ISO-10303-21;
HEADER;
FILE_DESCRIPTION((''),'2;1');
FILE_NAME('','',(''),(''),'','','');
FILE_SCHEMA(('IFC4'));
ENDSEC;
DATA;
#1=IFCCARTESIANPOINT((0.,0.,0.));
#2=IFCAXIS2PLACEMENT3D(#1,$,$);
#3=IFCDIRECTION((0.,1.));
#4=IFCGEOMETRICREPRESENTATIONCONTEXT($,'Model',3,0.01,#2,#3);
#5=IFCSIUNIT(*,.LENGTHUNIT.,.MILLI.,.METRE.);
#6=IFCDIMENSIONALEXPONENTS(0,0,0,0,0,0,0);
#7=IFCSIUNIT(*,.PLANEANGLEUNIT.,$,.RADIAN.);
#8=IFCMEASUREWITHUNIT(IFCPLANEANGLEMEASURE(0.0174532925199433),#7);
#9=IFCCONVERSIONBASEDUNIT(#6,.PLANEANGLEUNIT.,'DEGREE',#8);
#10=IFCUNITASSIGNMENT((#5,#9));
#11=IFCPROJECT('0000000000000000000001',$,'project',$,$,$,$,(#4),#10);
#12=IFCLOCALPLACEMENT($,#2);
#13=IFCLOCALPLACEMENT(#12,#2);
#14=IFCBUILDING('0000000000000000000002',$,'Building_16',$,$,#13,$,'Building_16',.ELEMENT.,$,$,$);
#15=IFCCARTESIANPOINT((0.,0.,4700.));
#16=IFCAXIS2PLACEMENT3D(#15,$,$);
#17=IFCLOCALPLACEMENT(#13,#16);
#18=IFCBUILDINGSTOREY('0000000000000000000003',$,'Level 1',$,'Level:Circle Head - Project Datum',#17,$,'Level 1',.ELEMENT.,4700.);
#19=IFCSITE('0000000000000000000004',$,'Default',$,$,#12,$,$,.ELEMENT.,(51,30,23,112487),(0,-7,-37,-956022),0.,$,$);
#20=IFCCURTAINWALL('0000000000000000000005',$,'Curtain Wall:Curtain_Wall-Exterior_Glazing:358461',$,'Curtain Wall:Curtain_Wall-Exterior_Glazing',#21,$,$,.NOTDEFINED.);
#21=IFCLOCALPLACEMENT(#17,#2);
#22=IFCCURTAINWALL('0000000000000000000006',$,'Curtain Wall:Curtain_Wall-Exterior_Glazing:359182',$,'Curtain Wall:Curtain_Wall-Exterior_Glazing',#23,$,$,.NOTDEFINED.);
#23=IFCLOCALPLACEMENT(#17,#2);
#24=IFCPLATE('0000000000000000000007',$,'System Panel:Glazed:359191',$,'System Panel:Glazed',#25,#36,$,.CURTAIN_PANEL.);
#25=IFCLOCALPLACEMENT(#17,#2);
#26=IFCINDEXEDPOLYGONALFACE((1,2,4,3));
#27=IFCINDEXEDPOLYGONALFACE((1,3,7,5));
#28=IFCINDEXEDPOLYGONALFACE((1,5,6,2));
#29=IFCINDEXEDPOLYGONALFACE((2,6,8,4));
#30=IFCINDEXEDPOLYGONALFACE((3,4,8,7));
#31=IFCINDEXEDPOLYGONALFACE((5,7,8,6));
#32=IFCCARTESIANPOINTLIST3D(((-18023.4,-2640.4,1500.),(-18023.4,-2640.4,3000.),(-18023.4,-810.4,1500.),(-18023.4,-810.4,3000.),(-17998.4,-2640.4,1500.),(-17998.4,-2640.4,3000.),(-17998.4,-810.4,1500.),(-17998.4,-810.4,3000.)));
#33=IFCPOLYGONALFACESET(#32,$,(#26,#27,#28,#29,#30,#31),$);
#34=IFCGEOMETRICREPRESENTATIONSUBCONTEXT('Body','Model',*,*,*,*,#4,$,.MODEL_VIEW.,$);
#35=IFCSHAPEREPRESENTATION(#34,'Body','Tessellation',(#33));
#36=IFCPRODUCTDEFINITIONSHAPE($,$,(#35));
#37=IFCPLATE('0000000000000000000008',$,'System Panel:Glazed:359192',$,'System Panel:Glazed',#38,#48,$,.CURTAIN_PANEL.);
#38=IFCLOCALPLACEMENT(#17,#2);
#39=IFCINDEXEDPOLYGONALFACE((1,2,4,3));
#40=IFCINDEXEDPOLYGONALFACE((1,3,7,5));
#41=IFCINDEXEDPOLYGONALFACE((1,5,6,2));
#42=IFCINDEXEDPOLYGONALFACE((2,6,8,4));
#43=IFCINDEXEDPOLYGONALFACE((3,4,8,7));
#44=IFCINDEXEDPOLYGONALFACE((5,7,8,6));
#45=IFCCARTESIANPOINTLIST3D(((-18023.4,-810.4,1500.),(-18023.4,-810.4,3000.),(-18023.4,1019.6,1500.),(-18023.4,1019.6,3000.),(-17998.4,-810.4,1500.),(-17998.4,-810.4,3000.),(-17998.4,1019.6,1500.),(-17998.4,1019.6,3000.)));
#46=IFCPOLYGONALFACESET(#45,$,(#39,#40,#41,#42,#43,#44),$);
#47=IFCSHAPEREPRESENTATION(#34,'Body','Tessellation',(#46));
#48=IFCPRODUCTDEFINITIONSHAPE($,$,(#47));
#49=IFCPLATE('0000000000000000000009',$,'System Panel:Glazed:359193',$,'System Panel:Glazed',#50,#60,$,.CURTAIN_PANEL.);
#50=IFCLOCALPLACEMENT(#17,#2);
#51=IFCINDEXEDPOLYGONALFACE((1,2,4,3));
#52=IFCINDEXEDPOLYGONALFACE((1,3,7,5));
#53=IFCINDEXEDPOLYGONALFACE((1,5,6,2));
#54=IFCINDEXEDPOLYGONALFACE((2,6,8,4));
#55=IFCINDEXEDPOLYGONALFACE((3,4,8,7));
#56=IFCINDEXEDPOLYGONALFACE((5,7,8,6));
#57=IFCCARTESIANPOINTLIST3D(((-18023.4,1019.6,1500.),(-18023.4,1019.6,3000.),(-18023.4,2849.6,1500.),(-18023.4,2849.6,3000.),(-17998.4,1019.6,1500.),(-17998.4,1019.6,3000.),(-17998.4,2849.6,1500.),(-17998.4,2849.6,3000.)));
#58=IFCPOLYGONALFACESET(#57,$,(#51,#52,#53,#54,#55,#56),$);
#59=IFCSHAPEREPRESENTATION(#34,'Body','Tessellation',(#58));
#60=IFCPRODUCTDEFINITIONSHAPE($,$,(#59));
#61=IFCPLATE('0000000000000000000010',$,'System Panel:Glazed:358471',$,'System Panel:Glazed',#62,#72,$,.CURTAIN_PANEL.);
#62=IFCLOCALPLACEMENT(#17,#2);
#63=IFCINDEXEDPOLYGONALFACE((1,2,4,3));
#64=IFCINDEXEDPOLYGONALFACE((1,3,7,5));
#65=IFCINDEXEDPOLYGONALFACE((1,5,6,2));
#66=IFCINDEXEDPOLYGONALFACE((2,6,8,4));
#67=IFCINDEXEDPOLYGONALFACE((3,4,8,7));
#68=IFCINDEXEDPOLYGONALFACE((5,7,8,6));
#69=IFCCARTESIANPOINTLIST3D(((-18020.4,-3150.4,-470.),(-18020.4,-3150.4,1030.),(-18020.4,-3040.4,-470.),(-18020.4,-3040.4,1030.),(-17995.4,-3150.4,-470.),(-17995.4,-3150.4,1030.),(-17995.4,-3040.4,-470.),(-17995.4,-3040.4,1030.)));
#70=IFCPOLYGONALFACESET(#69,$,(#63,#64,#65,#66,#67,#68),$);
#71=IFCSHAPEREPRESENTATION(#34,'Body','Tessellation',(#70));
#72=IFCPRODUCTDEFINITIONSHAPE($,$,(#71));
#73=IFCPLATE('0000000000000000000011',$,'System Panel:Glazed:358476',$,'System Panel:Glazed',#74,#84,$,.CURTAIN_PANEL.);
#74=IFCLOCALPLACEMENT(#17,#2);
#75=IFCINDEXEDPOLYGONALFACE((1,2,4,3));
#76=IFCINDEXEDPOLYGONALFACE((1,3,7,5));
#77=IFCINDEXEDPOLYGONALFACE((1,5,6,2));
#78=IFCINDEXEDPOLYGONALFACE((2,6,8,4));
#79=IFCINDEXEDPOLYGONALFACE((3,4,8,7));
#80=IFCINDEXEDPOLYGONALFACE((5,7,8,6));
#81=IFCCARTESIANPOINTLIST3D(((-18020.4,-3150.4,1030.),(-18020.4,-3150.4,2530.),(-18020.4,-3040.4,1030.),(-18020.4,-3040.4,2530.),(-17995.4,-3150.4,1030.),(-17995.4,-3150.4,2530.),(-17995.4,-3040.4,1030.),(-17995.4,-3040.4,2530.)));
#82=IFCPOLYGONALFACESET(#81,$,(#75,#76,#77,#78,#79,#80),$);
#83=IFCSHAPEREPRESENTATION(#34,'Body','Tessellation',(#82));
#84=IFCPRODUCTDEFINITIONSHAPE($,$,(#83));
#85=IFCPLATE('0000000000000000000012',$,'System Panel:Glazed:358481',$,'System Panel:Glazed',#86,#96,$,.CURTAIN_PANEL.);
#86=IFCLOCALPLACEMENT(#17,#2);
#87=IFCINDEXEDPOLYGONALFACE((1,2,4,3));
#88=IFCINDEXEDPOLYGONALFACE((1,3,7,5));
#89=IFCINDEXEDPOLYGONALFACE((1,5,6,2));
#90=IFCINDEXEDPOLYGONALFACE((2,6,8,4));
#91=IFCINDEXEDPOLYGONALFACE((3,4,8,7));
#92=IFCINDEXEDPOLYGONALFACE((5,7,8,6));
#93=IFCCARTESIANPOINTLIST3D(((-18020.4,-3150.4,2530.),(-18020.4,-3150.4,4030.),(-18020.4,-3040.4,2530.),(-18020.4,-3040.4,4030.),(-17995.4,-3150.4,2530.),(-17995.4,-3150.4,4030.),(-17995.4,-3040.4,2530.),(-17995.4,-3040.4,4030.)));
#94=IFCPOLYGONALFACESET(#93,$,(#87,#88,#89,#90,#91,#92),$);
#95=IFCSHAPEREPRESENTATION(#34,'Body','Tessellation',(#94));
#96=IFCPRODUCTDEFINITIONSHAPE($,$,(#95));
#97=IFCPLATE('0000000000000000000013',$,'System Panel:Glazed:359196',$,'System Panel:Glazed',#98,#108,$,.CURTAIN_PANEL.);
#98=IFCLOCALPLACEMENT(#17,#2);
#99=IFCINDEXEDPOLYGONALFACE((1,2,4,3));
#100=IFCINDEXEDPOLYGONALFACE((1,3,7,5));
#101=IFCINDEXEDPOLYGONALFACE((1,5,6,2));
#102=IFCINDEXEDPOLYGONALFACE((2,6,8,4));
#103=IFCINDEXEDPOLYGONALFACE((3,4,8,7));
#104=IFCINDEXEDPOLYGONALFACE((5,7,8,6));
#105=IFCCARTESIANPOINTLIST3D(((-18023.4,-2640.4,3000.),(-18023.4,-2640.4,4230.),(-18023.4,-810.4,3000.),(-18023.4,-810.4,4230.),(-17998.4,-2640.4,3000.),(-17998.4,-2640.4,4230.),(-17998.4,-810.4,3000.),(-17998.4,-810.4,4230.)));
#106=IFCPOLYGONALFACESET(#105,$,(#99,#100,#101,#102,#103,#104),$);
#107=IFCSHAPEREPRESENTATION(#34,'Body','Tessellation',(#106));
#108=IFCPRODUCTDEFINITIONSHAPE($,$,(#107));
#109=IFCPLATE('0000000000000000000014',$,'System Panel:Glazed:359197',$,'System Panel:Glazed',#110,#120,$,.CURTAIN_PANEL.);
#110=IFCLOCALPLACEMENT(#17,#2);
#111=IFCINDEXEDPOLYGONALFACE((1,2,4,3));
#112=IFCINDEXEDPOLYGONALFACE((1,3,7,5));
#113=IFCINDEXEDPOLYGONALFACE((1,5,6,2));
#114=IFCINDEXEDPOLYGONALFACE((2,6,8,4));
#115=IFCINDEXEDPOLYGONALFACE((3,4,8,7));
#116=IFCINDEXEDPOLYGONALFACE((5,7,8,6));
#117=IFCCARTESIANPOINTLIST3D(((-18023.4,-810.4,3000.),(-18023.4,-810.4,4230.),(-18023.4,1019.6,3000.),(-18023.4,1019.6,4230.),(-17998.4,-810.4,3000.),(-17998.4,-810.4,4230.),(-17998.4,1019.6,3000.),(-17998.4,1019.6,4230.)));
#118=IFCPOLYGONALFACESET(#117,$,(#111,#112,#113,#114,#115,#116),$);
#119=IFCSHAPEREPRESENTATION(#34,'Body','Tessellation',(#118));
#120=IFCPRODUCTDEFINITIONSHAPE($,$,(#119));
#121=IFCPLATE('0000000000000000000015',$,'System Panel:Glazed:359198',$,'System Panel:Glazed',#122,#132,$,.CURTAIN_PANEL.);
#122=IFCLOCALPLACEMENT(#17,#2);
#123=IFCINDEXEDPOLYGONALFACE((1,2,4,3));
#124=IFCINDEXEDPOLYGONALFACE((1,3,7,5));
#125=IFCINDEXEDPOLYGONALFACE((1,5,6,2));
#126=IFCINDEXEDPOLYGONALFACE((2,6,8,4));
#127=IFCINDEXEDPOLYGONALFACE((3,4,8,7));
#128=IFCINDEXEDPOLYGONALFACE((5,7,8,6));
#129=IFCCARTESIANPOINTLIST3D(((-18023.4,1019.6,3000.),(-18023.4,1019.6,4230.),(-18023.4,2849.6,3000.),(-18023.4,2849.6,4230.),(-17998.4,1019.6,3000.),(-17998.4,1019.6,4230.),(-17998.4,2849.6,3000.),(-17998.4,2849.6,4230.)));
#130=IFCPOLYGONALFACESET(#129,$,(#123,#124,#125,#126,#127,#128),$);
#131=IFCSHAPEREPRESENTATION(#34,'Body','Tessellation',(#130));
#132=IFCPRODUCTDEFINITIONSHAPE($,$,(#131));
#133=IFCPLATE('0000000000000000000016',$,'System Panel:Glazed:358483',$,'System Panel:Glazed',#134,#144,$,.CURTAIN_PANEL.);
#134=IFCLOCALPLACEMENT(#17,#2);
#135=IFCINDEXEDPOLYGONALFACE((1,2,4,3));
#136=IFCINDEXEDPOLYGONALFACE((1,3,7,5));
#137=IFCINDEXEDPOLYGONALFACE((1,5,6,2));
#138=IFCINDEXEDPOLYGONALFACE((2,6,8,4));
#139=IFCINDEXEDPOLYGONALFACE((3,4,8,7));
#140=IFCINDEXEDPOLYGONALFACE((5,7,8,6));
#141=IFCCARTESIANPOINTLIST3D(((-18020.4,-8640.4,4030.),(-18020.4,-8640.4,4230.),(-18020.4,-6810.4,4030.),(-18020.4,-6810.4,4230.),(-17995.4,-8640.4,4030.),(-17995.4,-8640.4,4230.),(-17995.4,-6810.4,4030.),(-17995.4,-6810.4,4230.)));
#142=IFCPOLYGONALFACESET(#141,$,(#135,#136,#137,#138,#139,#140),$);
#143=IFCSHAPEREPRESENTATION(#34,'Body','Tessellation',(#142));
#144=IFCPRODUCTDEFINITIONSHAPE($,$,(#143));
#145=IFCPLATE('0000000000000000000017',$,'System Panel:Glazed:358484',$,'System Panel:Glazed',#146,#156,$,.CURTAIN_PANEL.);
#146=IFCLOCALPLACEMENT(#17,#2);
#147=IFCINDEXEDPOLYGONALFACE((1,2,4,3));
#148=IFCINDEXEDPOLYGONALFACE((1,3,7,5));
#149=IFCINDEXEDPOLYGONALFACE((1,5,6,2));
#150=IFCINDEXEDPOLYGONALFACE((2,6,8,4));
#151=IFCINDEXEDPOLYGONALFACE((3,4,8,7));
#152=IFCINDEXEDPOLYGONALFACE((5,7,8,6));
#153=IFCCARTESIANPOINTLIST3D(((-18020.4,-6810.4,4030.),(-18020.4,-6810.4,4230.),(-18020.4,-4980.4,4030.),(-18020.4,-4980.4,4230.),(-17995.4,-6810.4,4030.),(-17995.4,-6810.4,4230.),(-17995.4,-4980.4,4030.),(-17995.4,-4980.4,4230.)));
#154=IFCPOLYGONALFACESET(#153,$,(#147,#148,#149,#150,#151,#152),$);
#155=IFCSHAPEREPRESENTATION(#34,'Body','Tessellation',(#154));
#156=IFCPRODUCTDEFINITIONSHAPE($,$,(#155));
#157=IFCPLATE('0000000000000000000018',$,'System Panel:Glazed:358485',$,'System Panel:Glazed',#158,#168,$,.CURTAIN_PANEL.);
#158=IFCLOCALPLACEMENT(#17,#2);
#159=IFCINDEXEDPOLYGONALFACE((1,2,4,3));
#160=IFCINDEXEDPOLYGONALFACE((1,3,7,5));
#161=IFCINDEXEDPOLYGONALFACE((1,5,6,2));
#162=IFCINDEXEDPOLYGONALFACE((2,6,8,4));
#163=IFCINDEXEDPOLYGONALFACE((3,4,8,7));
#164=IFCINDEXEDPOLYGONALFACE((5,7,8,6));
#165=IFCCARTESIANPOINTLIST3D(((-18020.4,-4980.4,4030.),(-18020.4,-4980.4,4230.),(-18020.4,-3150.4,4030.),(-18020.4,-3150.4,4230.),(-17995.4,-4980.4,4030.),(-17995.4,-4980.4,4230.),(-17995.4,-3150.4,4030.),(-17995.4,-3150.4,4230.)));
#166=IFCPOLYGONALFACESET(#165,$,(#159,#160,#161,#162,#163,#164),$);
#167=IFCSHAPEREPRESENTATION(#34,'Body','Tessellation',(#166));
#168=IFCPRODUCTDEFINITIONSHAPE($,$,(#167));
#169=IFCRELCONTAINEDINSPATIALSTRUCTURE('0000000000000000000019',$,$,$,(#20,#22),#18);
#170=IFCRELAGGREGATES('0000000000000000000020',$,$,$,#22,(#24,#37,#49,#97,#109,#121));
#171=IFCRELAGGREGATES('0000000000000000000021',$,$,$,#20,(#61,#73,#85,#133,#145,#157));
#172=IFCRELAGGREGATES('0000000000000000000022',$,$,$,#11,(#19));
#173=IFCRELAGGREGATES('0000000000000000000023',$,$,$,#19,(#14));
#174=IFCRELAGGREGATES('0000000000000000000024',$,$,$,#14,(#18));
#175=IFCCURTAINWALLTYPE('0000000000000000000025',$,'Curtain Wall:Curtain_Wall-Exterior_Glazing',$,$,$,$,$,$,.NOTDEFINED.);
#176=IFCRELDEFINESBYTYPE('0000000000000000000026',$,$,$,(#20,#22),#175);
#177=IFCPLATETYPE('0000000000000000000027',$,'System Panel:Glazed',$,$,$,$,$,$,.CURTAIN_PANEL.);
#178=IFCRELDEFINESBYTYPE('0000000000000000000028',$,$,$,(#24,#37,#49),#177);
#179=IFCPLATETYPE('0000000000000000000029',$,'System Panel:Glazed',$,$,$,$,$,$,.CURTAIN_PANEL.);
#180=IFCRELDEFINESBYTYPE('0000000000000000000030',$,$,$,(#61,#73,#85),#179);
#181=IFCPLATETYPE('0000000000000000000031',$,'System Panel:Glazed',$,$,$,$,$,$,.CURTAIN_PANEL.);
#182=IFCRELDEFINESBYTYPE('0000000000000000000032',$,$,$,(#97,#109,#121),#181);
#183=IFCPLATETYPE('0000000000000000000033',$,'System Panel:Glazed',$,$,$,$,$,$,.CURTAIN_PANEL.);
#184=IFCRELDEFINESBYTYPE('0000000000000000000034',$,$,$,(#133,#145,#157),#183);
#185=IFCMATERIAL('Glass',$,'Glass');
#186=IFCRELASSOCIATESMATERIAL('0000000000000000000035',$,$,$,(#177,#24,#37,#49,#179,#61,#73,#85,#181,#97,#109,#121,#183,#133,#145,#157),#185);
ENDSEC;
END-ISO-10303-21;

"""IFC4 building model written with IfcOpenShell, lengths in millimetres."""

from ifc_helpers import new_model, entity, si_unit, converted_unit, direction, frame, origin, place, context, subcontext, project, spatial, indexed_curve, outline, extrude, source, transform, mapped, material, type_object, type_shapes, element, aggregate, save


model = new_model("IFC4")

# Units and contexts
model_context = context("Model", 3, precision=0.01, world=origin(), true_north=direction((0.0, 1.0)))
body_context = subcontext(model_context, "Body", "Model", "MODEL_VIEW")
ifc_project = project(units=[si_unit("LENGTHUNIT", "METRE", prefix="MILLI"), converted_unit("PLANEANGLEUNIT", "DEGREE", entity("IfcPlaneAngleMeasure", 0.0174532925199433), si_unit("PLANEANGLEUNIT", "RADIAN"), dimensions=[0, 0, 0, 0, 0, 0, 0])], contexts=[model_context])

# Site, building, storey
site_placement = place(None, origin())
site = spatial("IfcSite", under=ifc_project, at=site_placement, Name="Default", CompositionType="ELEMENT", RefLatitude=(51, 30, 23, 112487), RefLongitude=(0, -7, -37, -956022), RefElevation=0.0)
building_placement = place(site_placement, origin())
building = spatial("IfcBuilding", under=site, at=building_placement, Name="Building_16", LongName="Building_16", CompositionType="ELEMENT")
storey_placement = place(building_placement, frame((0.0, 0.0, 4700.0)))
storey = spatial("IfcBuildingStorey", under=building, at=storey_placement, Name="Level 1", ObjectType="Level:Circle Head - Project Datum", LongName="Level 1", CompositionType="ELEMENT", Elevation=4700.0)

# Curtain walls, plates
curtain_wall_type = type_object("IfcCurtainWallType", Name="Curtain Wall:Curtain_Wall-Exterior_Glazing", PredefinedType="NOTDEFINED")
curtain_wall_1_placement = place(storey_placement, frame((0.0, 0.0, -4700.0)))
curtain_wall_1 = element("IfcCurtainWall", 1, at=curtain_wall_1_placement, inside=storey, type_object=curtain_wall_type, Name="Curtain Wall:Curtain_Wall-Exterior_Glazing:358461", ObjectType="Curtain Wall:Curtain_Wall-Exterior_Glazing", PredefinedType="NOTDEFINED")
ifc_material_1 = material(Name="Glass", Category="Glass")
plate_type_1 = type_object("IfcPlateType", Name="System Panel:Glazed", PredefinedType="CURTAIN_PANEL", material=ifc_material_1)
shared_shape_1 = source(origin(), body_context, "Body", "SweptSolid", [
    extrude(outline(indexed_curve([(-12.5, -915.0), (12.5, -915.0), (12.5, 915.0), (-12.5, 915.0), (-12.5, -915.0)], self_intersect=False)), frame((0.0, 37.0, 0.0), z_axis=(0.0, 0.0, 1.0), x_axis=(0.0, 1.0, 0.0)), (0.0, 0.0, 1.0), 1500.0),
])
type_shapes(plate_type_1, [shared_shape_1])
curtain_wall_2_placement = place(storey_placement, frame((0.0, 0.0, -4700.0)))
curtain_wall_2 = element("IfcCurtainWall", 2, at=curtain_wall_2_placement, inside=storey, type_object=curtain_wall_type, Name="Curtain Wall:Curtain_Wall-Exterior_Glazing:359182", ObjectType="Curtain Wall:Curtain_Wall-Exterior_Glazing", PredefinedType="NOTDEFINED")
plate_1_placement = place(curtain_wall_2_placement, frame((-17973.9, -1725.4, 6200.0), z_axis=(0.0, 0.0, 1.0), x_axis=(0.0, 1.0, 0.0)))
plate_1 = element("IfcPlate", 3, at=plate_1_placement, type_object=plate_type_1, material=ifc_material_1, Name="System Panel:Glazed:359191", ObjectType="System Panel:Glazed", PredefinedType="CURTAIN_PANEL", context=body_context, shape_type="MappedRepresentation", body=[
    mapped(shared_shape_1, transform((0.0, 0.0, 0.0), scale=1.0)),
])
plate_2_placement = place(curtain_wall_2_placement, frame((-17973.9, 104.6, 6200.0), z_axis=(0.0, 0.0, 1.0), x_axis=(0.0, 1.0, 0.0)))
plate_2 = element("IfcPlate", 4, at=plate_2_placement, type_object=plate_type_1, material=ifc_material_1, Name="System Panel:Glazed:359192", ObjectType="System Panel:Glazed", PredefinedType="CURTAIN_PANEL", context=body_context, shape_type="MappedRepresentation", body=[
    mapped(shared_shape_1, transform((0.0, 0.0, 0.0), scale=1.0)),
])
plate_3_placement = place(curtain_wall_2_placement, frame((-17973.9, 1934.6, 6200.0), z_axis=(0.0, 0.0, 1.0), x_axis=(0.0, 1.0, 0.0)))
plate_3 = element("IfcPlate", 5, at=plate_3_placement, type_object=plate_type_1, material=ifc_material_1, Name="System Panel:Glazed:359193", ObjectType="System Panel:Glazed", PredefinedType="CURTAIN_PANEL", context=body_context, shape_type="MappedRepresentation", body=[
    mapped(shared_shape_1, transform((0.0, 0.0, 0.0), scale=1.0)),
])

# Plates
plate_type_2 = type_object("IfcPlateType", Name="System Panel:Glazed", PredefinedType="CURTAIN_PANEL", material=ifc_material_1)
shared_shape_2 = source(origin(), body_context, "Body", "SweptSolid", [
    extrude(outline(indexed_curve([(-12.5, -55.0), (12.5, -55.0), (12.5, 55.0), (-12.5, 55.0), (-12.5, -55.0)], self_intersect=False)), frame((0.0, 37.0, 0.0), z_axis=(0.0, 0.0, 1.0), x_axis=(0.0, 1.0, 0.0)), (0.0, 0.0, 1.0), 1500.0),
])
type_shapes(plate_type_2, [shared_shape_2])
plate_4_placement = place(curtain_wall_1_placement, frame((-17970.9, -3095.4, 4230.0), z_axis=(0.0, 0.0, 1.0), x_axis=(0.0, 1.0, 0.0)))
plate_4 = element("IfcPlate", 6, at=plate_4_placement, type_object=plate_type_2, material=ifc_material_1, Name="System Panel:Glazed:358471", ObjectType="System Panel:Glazed", PredefinedType="CURTAIN_PANEL", context=body_context, shape_type="MappedRepresentation", body=[
    mapped(shared_shape_2, transform((0.0, 0.0, 0.0), scale=1.0)),
])
plate_5_placement = place(curtain_wall_1_placement, frame((-17970.9, -3095.4, 5730.0), z_axis=(0.0, 0.0, 1.0), x_axis=(0.0, 1.0, 0.0)))
plate_5 = element("IfcPlate", 7, at=plate_5_placement, type_object=plate_type_2, material=ifc_material_1, Name="System Panel:Glazed:358476", ObjectType="System Panel:Glazed", PredefinedType="CURTAIN_PANEL", context=body_context, shape_type="MappedRepresentation", body=[
    mapped(shared_shape_2, transform((0.0, 0.0, 0.0), scale=1.0)),
])
plate_6_placement = place(curtain_wall_1_placement, frame((-17970.9, -3095.4, 7230.0), z_axis=(0.0, 0.0, 1.0), x_axis=(0.0, 1.0, 0.0)))
plate_6 = element("IfcPlate", 8, at=plate_6_placement, type_object=plate_type_2, material=ifc_material_1, Name="System Panel:Glazed:358481", ObjectType="System Panel:Glazed", PredefinedType="CURTAIN_PANEL", context=body_context, shape_type="MappedRepresentation", body=[
    mapped(shared_shape_2, transform((0.0, 0.0, 0.0), scale=1.0)),
])
plate_type_3 = type_object("IfcPlateType", Name="System Panel:Glazed", PredefinedType="CURTAIN_PANEL", material=ifc_material_1)
shared_shape_3 = source(origin(), body_context, "Body", "SweptSolid", [
    extrude(outline(indexed_curve([(-12.5, -915.0), (12.5, -915.0), (12.5, 915.0), (-12.5, 915.0), (-12.5, -915.0)], self_intersect=False)), frame((0.0, 37.0, 0.0), z_axis=(0.0, 0.0, 1.0), x_axis=(0.0, 1.0, 0.0)), (0.0, 0.0, 1.0), 1230.0),
])
type_shapes(plate_type_3, [shared_shape_3])
plate_7_placement = place(curtain_wall_2_placement, frame((-17973.9, -1725.4, 7700.0), z_axis=(0.0, 0.0, 1.0), x_axis=(0.0, 1.0, 0.0)))
plate_7 = element("IfcPlate", 9, at=plate_7_placement, type_object=plate_type_3, material=ifc_material_1, Name="System Panel:Glazed:359196", ObjectType="System Panel:Glazed", PredefinedType="CURTAIN_PANEL", context=body_context, shape_type="MappedRepresentation", body=[
    mapped(shared_shape_3, transform((0.0, 0.0, 0.0), scale=1.0)),
])
plate_8_placement = place(curtain_wall_2_placement, frame((-17973.9, 104.6, 7700.0), z_axis=(0.0, 0.0, 1.0), x_axis=(0.0, 1.0, 0.0)))
plate_8 = element("IfcPlate", 10, at=plate_8_placement, type_object=plate_type_3, material=ifc_material_1, Name="System Panel:Glazed:359197", ObjectType="System Panel:Glazed", PredefinedType="CURTAIN_PANEL", context=body_context, shape_type="MappedRepresentation", body=[
    mapped(shared_shape_3, transform((0.0, 0.0, 0.0), scale=1.0)),
])
plate_9_placement = place(curtain_wall_2_placement, frame((-17973.9, 1934.6, 7700.0), z_axis=(0.0, 0.0, 1.0), x_axis=(0.0, 1.0, 0.0)))
plate_9 = element("IfcPlate", 11, at=plate_9_placement, type_object=plate_type_3, material=ifc_material_1, Name="System Panel:Glazed:359198", ObjectType="System Panel:Glazed", PredefinedType="CURTAIN_PANEL", context=body_context, shape_type="MappedRepresentation", body=[
    mapped(shared_shape_3, transform((0.0, 0.0, 0.0), scale=1.0)),
])
aggregate(curtain_wall_2, [plate_1, plate_2, plate_3, plate_7, plate_8, plate_9])
plate_type_4 = type_object("IfcPlateType", Name="System Panel:Glazed", PredefinedType="CURTAIN_PANEL", material=ifc_material_1)
shared_shape_4 = source(origin(), body_context, "Body", "SweptSolid", [
    extrude(outline(indexed_curve([(-12.5, -915.0), (12.5, -915.0), (12.5, 915.0), (-12.5, 915.0), (-12.5, -915.0)], self_intersect=False)), frame((0.0, 37.0, 0.0), z_axis=(0.0, 0.0, 1.0), x_axis=(0.0, 1.0, 0.0)), (0.0, 0.0, 1.0), 200.0),
])
type_shapes(plate_type_4, [shared_shape_4])
plate_10_placement = place(curtain_wall_1_placement, frame((-17970.9, -7725.4, 8730.0), z_axis=(0.0, 0.0, 1.0), x_axis=(0.0, 1.0, 0.0)))
plate_10 = element("IfcPlate", 12, at=plate_10_placement, type_object=plate_type_4, material=ifc_material_1, Name="System Panel:Glazed:358483", ObjectType="System Panel:Glazed", PredefinedType="CURTAIN_PANEL", context=body_context, shape_type="MappedRepresentation", body=[
    mapped(shared_shape_4, transform((0.0, 0.0, 0.0), scale=1.0)),
])
plate_11_placement = place(curtain_wall_1_placement, frame((-17970.9, -5895.4, 8730.0), z_axis=(0.0, 0.0, 1.0), x_axis=(0.0, 1.0, 0.0)))
plate_11 = element("IfcPlate", 13, at=plate_11_placement, type_object=plate_type_4, material=ifc_material_1, Name="System Panel:Glazed:358484", ObjectType="System Panel:Glazed", PredefinedType="CURTAIN_PANEL", context=body_context, shape_type="MappedRepresentation", body=[
    mapped(shared_shape_4, transform((0.0, 0.0, 0.0), scale=1.0)),
])
plate_12_placement = place(curtain_wall_1_placement, frame((-17970.9, -4065.4, 8730.0), z_axis=(0.0, 0.0, 1.0), x_axis=(0.0, 1.0, 0.0)))
plate_12 = element("IfcPlate", 14, at=plate_12_placement, type_object=plate_type_4, material=ifc_material_1, Name="System Panel:Glazed:358485", ObjectType="System Panel:Glazed", PredefinedType="CURTAIN_PANEL", context=body_context, shape_type="MappedRepresentation", body=[
    mapped(shared_shape_4, transform((0.0, 0.0, 0.0), scale=1.0)),
])
aggregate(curtain_wall_1, [plate_4, plate_5, plate_6, plate_10, plate_11, plate_12])

save(model, "model.ifc")
